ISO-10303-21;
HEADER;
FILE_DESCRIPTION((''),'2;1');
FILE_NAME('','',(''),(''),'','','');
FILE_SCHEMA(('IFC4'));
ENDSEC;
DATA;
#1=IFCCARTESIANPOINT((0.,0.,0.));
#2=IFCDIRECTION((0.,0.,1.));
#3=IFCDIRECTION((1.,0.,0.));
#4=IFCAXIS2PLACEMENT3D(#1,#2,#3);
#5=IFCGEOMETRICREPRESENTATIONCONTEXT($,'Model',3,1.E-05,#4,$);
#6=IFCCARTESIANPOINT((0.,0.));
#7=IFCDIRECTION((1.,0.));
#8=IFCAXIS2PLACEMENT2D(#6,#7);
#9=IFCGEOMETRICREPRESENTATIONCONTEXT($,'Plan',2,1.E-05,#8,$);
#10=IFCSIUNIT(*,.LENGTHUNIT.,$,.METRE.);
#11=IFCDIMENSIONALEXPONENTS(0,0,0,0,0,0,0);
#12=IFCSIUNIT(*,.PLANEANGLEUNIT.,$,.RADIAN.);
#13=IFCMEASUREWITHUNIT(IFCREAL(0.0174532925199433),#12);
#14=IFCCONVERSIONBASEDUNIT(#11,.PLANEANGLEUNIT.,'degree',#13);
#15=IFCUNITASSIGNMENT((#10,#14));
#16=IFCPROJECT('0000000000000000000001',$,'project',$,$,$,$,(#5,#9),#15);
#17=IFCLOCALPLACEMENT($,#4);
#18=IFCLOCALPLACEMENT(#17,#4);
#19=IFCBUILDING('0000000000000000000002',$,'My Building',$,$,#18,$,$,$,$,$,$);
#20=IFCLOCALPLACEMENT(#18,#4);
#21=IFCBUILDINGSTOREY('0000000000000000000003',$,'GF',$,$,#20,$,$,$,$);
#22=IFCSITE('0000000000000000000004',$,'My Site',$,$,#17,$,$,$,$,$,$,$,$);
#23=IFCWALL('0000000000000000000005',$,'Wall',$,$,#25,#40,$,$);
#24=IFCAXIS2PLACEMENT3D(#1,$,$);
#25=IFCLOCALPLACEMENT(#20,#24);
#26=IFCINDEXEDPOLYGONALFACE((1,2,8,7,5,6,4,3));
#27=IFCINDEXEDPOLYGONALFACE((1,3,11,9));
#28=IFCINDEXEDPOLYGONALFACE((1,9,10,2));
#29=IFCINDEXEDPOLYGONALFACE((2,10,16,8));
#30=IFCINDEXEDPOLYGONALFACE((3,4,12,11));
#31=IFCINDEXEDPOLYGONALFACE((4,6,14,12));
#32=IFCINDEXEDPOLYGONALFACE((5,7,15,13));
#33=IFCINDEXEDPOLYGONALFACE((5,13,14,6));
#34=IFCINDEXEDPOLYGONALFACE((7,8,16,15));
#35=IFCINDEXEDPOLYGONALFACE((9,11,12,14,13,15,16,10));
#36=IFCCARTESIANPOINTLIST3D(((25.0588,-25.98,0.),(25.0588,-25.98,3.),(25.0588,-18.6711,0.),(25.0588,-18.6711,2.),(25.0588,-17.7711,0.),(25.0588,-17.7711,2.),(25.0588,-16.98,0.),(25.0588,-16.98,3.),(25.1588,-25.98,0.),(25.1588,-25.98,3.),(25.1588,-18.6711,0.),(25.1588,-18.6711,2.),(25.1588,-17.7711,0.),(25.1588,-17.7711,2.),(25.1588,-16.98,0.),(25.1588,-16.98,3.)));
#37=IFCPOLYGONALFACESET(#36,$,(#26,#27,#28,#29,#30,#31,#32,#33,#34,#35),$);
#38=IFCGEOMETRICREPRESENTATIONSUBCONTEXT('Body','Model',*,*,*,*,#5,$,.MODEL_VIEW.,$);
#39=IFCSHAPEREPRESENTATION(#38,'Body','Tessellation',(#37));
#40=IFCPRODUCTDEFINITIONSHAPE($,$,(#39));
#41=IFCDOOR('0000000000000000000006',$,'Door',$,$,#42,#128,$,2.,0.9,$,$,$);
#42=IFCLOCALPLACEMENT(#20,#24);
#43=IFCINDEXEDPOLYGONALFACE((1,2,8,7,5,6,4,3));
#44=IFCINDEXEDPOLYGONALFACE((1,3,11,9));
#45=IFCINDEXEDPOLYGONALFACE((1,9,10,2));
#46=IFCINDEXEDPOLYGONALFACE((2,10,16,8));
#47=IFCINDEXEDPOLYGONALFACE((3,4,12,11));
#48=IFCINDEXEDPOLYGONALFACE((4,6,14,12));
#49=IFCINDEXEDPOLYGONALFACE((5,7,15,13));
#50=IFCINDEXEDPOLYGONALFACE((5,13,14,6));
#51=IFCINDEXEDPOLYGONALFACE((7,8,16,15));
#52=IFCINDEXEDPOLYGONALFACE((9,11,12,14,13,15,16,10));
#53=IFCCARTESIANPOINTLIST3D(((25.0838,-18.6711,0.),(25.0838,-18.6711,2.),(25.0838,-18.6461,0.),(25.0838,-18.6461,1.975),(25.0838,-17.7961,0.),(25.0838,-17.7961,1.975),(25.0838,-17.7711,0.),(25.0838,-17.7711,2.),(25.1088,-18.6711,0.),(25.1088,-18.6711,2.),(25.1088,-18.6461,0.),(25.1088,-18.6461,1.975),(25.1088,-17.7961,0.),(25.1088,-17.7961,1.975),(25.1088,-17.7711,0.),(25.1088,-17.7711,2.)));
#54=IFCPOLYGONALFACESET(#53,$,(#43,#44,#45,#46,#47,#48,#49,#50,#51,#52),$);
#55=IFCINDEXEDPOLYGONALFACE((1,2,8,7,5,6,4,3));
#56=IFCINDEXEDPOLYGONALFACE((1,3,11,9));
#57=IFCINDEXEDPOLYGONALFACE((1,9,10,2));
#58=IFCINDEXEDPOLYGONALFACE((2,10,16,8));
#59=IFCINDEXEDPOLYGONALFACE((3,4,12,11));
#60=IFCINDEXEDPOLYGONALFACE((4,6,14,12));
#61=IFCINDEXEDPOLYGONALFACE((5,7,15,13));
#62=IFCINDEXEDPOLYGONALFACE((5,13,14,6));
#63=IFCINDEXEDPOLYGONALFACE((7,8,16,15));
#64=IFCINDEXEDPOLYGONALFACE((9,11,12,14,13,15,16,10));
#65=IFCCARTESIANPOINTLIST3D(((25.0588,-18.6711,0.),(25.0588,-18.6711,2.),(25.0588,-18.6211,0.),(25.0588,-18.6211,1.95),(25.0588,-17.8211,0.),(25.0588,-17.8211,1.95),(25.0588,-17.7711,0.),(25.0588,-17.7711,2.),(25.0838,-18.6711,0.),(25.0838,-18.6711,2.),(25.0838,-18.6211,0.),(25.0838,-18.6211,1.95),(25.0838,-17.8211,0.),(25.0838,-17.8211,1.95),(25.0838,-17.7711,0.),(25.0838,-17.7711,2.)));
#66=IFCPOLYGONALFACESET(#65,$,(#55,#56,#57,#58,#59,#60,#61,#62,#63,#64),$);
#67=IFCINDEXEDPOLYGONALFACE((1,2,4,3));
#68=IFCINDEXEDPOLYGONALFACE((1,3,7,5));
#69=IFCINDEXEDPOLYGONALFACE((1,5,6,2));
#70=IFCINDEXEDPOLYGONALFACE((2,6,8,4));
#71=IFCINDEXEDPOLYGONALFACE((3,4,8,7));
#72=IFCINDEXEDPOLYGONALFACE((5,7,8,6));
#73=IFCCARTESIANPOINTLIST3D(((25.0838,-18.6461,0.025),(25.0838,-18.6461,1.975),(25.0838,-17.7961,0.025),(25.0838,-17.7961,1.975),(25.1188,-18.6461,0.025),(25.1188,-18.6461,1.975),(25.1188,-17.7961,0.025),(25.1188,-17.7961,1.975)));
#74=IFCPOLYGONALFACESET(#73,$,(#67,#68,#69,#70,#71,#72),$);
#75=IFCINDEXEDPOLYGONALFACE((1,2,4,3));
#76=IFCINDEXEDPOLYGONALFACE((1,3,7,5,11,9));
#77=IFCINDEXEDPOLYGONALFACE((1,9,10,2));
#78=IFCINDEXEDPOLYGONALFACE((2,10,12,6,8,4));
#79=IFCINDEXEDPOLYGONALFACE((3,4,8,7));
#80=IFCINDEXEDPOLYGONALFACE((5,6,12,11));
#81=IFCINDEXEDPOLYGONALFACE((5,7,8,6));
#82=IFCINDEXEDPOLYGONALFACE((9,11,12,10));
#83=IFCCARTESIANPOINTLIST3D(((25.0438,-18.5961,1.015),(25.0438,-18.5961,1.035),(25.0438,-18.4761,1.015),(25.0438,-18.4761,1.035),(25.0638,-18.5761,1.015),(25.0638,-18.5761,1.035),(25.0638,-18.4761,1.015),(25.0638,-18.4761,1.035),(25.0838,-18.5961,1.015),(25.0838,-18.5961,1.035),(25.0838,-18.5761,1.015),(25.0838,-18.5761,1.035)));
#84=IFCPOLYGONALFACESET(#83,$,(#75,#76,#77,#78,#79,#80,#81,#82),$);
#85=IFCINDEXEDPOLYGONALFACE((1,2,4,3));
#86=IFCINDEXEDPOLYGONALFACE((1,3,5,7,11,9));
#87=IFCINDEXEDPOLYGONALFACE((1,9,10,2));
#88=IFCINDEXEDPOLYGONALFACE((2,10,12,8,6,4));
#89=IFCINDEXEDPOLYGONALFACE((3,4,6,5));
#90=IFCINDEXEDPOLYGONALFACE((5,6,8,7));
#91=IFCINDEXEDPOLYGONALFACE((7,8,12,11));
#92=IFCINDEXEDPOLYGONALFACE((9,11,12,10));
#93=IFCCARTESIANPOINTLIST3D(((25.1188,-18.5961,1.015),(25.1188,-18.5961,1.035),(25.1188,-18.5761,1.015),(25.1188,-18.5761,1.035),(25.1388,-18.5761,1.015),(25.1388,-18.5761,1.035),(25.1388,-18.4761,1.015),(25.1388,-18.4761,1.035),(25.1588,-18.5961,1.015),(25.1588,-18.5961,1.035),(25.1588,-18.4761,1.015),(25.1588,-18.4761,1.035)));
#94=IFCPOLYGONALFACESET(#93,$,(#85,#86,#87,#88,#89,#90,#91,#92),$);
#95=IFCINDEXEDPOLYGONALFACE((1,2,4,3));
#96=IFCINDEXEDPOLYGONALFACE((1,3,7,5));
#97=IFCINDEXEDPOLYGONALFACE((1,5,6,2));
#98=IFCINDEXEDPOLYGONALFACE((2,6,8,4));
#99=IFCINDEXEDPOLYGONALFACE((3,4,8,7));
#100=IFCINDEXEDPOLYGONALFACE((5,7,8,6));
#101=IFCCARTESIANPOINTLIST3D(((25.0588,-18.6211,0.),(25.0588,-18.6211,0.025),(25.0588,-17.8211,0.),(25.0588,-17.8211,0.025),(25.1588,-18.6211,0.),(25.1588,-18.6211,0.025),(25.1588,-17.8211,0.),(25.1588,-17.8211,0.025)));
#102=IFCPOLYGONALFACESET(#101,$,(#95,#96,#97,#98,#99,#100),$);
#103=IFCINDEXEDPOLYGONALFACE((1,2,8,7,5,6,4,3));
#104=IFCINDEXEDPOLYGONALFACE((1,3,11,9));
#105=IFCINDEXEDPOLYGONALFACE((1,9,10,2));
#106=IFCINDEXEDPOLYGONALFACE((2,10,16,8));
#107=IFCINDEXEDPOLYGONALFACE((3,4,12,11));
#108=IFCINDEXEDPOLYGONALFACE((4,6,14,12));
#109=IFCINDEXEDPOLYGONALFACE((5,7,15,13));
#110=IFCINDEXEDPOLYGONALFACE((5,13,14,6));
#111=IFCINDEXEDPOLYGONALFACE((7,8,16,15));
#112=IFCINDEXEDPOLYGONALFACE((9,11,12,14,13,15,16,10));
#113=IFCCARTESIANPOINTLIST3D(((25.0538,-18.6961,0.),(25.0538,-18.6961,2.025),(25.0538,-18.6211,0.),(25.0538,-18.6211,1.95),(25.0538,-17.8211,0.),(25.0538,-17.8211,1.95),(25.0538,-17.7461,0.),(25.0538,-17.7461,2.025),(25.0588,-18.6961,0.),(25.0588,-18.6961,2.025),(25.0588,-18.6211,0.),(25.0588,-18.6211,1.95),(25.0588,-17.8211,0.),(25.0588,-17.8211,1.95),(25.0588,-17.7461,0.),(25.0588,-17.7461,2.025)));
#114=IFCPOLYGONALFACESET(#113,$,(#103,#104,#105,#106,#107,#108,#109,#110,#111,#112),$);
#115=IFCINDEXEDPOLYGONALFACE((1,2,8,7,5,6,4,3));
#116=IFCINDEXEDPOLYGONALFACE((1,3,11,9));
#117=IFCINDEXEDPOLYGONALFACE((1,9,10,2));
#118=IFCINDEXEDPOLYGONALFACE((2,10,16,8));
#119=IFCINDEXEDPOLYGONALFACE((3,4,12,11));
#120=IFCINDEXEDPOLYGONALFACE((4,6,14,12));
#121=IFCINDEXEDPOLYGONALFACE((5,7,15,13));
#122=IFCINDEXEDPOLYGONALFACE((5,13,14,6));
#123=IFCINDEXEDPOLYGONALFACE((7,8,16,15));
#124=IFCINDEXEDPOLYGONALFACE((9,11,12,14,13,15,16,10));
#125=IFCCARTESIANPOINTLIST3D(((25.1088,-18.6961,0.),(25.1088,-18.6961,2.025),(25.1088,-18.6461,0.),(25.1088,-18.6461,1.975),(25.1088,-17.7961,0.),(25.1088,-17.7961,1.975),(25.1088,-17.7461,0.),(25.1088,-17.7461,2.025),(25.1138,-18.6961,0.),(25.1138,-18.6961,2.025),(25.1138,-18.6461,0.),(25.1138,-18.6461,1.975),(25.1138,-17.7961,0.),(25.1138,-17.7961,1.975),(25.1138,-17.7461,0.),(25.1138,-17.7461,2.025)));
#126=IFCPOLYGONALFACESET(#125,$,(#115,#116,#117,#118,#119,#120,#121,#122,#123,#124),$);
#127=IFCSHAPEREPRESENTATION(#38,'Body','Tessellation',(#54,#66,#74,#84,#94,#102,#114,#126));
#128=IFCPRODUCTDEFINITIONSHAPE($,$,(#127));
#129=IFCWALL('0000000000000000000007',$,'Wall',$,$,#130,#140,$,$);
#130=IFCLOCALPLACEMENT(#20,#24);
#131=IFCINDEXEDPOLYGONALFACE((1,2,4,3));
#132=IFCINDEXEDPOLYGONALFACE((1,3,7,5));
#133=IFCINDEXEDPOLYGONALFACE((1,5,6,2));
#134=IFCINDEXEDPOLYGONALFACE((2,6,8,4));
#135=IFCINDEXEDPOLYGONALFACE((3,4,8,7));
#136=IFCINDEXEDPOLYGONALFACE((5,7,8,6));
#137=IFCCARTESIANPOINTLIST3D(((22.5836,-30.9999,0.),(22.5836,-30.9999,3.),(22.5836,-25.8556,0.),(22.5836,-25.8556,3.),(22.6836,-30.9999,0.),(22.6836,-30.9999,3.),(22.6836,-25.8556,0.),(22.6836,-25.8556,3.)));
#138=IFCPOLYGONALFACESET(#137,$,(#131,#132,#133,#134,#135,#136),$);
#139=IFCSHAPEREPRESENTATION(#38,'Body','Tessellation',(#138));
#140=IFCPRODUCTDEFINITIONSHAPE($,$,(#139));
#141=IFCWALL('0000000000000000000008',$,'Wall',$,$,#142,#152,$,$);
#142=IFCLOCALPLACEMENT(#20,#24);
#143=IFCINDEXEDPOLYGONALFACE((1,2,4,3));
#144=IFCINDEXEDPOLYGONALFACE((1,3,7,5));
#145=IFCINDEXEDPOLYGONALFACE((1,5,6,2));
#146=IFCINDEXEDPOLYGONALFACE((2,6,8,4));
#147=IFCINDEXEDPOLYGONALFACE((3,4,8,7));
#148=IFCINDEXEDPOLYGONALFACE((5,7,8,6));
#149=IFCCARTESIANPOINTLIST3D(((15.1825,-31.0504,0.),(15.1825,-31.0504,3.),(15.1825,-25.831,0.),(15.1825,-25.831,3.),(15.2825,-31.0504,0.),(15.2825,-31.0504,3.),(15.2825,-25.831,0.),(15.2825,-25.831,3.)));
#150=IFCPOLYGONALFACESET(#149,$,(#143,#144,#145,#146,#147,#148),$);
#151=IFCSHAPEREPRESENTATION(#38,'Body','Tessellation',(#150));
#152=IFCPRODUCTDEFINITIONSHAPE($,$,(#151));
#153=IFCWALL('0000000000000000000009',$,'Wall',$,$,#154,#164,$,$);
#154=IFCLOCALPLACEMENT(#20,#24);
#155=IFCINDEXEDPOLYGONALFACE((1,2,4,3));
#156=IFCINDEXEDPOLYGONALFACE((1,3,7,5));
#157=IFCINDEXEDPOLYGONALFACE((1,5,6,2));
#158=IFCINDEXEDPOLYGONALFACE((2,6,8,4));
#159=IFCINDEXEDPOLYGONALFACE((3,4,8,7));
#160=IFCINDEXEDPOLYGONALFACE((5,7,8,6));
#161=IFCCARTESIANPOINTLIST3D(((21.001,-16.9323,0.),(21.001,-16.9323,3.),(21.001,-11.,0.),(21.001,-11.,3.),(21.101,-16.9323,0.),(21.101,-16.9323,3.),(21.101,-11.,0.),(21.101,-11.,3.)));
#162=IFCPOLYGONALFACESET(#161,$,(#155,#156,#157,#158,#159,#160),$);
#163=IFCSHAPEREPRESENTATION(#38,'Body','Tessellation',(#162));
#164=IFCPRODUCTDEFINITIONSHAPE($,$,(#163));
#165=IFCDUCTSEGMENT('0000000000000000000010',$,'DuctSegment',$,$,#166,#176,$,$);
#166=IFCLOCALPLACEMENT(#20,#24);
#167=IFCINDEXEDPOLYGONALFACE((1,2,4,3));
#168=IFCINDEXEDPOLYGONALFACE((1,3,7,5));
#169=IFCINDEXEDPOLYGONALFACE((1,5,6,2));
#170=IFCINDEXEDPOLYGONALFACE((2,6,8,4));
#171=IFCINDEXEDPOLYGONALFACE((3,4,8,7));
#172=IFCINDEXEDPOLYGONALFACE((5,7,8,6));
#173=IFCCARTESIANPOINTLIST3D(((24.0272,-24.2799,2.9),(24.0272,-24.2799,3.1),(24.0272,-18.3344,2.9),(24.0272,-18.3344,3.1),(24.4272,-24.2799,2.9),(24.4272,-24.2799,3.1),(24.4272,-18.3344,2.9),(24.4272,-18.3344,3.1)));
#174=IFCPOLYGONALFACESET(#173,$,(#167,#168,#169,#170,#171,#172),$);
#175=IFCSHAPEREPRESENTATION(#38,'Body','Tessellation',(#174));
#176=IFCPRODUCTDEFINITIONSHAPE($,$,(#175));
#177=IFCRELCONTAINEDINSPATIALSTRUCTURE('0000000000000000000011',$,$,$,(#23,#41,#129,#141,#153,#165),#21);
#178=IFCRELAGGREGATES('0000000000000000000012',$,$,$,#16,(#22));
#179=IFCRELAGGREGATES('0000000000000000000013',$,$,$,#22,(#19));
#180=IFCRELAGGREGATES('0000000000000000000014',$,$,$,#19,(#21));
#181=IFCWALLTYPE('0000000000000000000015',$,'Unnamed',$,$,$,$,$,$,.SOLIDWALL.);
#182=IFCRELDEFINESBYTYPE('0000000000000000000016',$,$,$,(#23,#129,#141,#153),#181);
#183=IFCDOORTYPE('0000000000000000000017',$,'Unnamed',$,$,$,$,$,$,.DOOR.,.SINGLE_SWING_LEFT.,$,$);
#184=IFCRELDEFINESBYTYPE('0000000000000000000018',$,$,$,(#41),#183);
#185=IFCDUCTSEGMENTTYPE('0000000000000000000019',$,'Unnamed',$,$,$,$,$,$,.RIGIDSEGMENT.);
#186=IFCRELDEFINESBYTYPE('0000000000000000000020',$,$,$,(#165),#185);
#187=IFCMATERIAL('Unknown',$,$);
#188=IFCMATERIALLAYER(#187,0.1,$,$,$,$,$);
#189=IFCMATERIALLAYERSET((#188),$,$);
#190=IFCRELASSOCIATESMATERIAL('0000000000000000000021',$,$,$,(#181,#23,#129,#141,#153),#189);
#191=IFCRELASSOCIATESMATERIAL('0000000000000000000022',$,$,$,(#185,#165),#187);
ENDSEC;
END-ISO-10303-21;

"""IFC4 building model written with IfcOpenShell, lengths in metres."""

from ifc_helpers import new_model, entity, si_unit, converted_unit, frame, origin_with_axes, origin_2d_with_axis, place, context, subcontext, project, spatial, line, indexed_curve, rectangle, outline, extrude, shape, source, transform, mapped, material, layer, layer_set, layer_usage, material_profile, profile_set, profile_usage, type_object, type_shapes, element, fill, save


model = new_model("IFC4")

# Units and contexts
model_context = context("Model", 3, precision=1e-05, world=origin_with_axes())
plan_context = context("Plan", 2, precision=1e-05, world=origin_2d_with_axis())
body_context_1 = subcontext(model_context, "Body", "Model", "MODEL_VIEW")
body_context_2 = subcontext(plan_context, "Body", "Plan", "PLAN_VIEW")
ifc_project = project(units=[si_unit("LENGTHUNIT", "METRE"), converted_unit("PLANEANGLEUNIT", "degree", entity("IfcReal", 0.0174532925199433), si_unit("PLANEANGLEUNIT", "RADIAN"), dimensions=[0, 0, 0, 0, 0, 0, 0])], contexts=[model_context, plan_context])

# Site, building, storey
site_placement = place(None, origin_with_axes())
site = spatial("IfcSite", under=ifc_project, at=site_placement, Name="My Site")
building_placement = place(site_placement, origin_with_axes())
building = spatial("IfcBuilding", under=site, at=building_placement, Name="My Building")
storey_placement = place(building_placement, origin_with_axes())
storey = spatial("IfcBuildingStorey", under=building, at=storey_placement, Name="GF")

# Shared definitions
ifc_material = material(Name="Unknown")
ifc_layer = layer(ifc_material, 0.1)
ifc_layer_set = layer_set([ifc_layer])
wall_type = type_object("IfcWallType", Name="Unnamed", PredefinedType="SOLIDWALL", material=ifc_layer_set)

# Shared definitions
shared_shape_1 = source(origin_with_axes(), body_context_1, "Body", "SweptSolid", [
    extrude(outline(indexed_curve([(0.0, 0.0), (0.9, 0.0), (0.9, 2.0), (0.0, 2.0)], segments=[line(1, 2, 3, 4, 1)])), frame((0.0, -0.6, 0.0), z_axis=(0.0, -1.0, 0.0), x_axis=(1.0, 0.0, 0.0)), (0.0, 0.0, -1.0), 1.2),
])
door_type = type_object("IfcDoorType", Name="Unnamed", OperationType="SINGLE_SWING_LEFT", PredefinedType="DOOR")
shared_shape_2 = source(origin_with_axes(), body_context_1, "Body", "SweptSolid", [
    extrude(outline(indexed_curve([(0.0, 0.0), (0.0, 2.0), (0.9, 2.0), (0.9, 0.0), (0.875, 0.0), (0.875, 1.975), (0.025, 1.975), (0.025, 0.0)], segments=[line(1, 2, 3, 4, 5, 6, 7, 8, 1)])), frame((0.0, 0.025, 0.0), z_axis=(0.0, -1.0, 0.0), x_axis=(1.0, 0.0, 0.0)), (0.0, 0.0, -1.0), 0.025),
    extrude(outline(indexed_curve([(0.0, 0.0), (0.0, 2.0), (0.9, 2.0), (0.9, 0.0), (0.85, 0.0), (0.85, 1.95), (0.05, 1.95), (0.05, 0.0)], segments=[line(1, 2, 3, 4, 5, 6, 7, 8, 1)])), frame((0.0, 0.0, 0.0), z_axis=(0.0, -1.0, 0.0), x_axis=(1.0, 0.0, 0.0)), (0.0, 0.0, -1.0), 0.025),
    extrude(outline(indexed_curve([(0.0, 0.0), (0.85, 0.0), (0.85, 0.035), (0.0, 0.035)], segments=[line(1, 2, 3, 4, 1)])), frame((0.025, 0.025, 0.025), z_axis=(0.0, 0.0, 1.0), x_axis=(1.0, 0.0, 0.0)), (0.0, 0.0, 1.0), 1.95),
    extrude(outline(indexed_curve([(0.0, 0.0), (0.0, -0.04), (-0.12, -0.04), (-0.12, -0.02), (-0.02, -0.02), (-0.02, 0.0)], segments=[line(1, 2, 3, 4, 5, 6, 1)])), frame((0.825, 0.025, 1.015), z_axis=(0.0, 0.0, 1.0), x_axis=(1.0, 0.0, 0.0)), (0.0, 0.0, 1.0), 0.02),
    extrude(outline(indexed_curve([(0.0, 0.0), (0.0, 0.04), (-0.12, 0.04), (-0.12, 0.02), (-0.02, 0.02), (-0.02, 0.0)], segments=[line(1, 2, 3, 4, 5, 6, 1)])), frame((0.825, 0.06, 1.015), z_axis=(0.0, 0.0, 1.0), x_axis=(1.0, 0.0, 0.0)), (0.0, 0.0, 1.0), 0.02),
    extrude(outline(indexed_curve([(0.0, 0.0), (0.8, 0.0), (0.8, 0.1), (0.0, 0.1)], segments=[line(1, 2, 3, 4, 1)])), frame((0.05, 0.0, 0.0), z_axis=(0.0, 0.0, 1.0), x_axis=(1.0, 0.0, 0.0)), (0.0, 0.0, 1.0), 0.025),
    extrude(outline(indexed_curve([(0.0, 0.0), (0.0, 2.025), (0.95, 2.025), (0.95, 0.0), (0.875, 0.0), (0.875, 1.95), (0.075, 1.95), (0.075, 0.0)], segments=[line(1, 2, 3, 4, 5, 6, 7, 8, 1)])), frame((-0.025, -0.005, 0.0), z_axis=(0.0, -1.0, 0.0), x_axis=(1.0, 0.0, 0.0)), (0.0, 0.0, -1.0), 0.005),
    extrude(outline(indexed_curve([(0.0, 0.0), (0.0, 2.025), (0.95, 2.025), (0.95, 0.0), (0.9, 0.0), (0.9, 1.975), (0.05, 1.975), (0.05, 0.0)], segments=[line(1, 2, 3, 4, 5, 6, 7, 8, 1)])), frame((-0.025, 0.05, 0.0), z_axis=(0.0, -1.0, 0.0), x_axis=(1.0, 0.0, 0.0)), (0.0, 0.0, -1.0), 0.005),
])
shared_shape_3 = source(origin_with_axes(), body_context_2, "Body", "Curve2D", [
    entity("IfcIndexedPolyCurve", entity("IfcCartesianPointList2D", [[0.0, 0.0], [0.0, 0.05], [0.025, 0.05], [0.025, 0.025], [0.05, 0.025], [0.05, 0.0]]), [entity("IfcLineIndex", [1, 2, 3, 4, 5, 6, 1])]),
    entity("IfcIndexedPolyCurve", entity("IfcCartesianPointList2D", [[0.9, 0.0], [0.9, 0.05], [0.875, 0.05], [0.875, 0.025], [0.85, 0.025], [0.85, 0.0]]), [entity("IfcLineIndex", [1, 2, 3, 4, 5, 6, 1])]),
    entity("IfcTrimmedCurve", entity("IfcEllipse", entity("IfcAxis2Placement2D", entity("IfcCartesianPoint", [0.06, 0.05]), entity("IfcDirection", [1.0, 0.0])), 0.815, 0.85), [entity("IfcCartesianPoint", [0.875, 0.05])], [entity("IfcCartesianPoint", [0.06, 0.9])], True, "CARTESIAN"),
    entity("IfcIndexedPolyCurve", entity("IfcCartesianPointList2D", [[0.025, 0.05], [0.06, 0.05], [0.06, 0.9], [0.025, 0.9]]), [entity("IfcLineIndex", [1, 2, 3, 4, 1])]),
])
type_shapes(door_type, [shared_shape_2, shared_shape_3])

# Wall, opening, door
ifc_layer_usage_1 = layer_usage(ifc_layer_set, "AXIS2", "POSITIVE", 0.0)
wall_1_placement = place(storey_placement, frame((25.0588, -16.98, 0.0), z_axis=(0.0, 0.0, 1.0), x_axis=(0.0, -1.0, 0.0)))
wall_1 = element("IfcWall", 1, at=wall_1_placement, inside=storey, type_object=wall_type, material=ifc_layer_usage_1, Name="Wall", context=body_context_1, shape_type="SweptSolid", body=[
    extrude(outline(indexed_curve([(0.0, 0.0), (0.0, 0.1), (9.0, 0.1), (9.0, 0.0)], segments=[line(1, 2, 3, 4, 1)])), origin_with_axes(), (0.0, 0.0, 1.0), 3.0),
])
opening_1_placement = place(wall_1_placement, frame((0.7911, 0.0, 0.0), z_axis=(0.0, 0.0, 1.0), x_axis=(1.0, 0.0, 0.0)))
opening_1 = element("IfcOpeningElement", 2, at=opening_1_placement, cuts=wall_1, PredefinedType="OPENING", context=body_context_1, shape_type="MappedRepresentation", body=[
    mapped(shared_shape_1, transform((0.0, 0.0, 0.0), x_axis=(1.0, 0.0, 0.0), y_axis=(0.0, 1.0, 0.0), z_axis=(0.0, 0.0, 1.0), scale=1.0)),
])
door_1_placement = place(opening_1_placement, frame((0.0, 0.0, 0.0), z_axis=(0.0, 0.0, 1.0), x_axis=(1.0, 0.0, 0.0)))
door_1 = element("IfcDoor", 3, at=door_1_placement, inside=storey, type_object=door_type, Name="Door", OverallHeight=2.0, OverallWidth=0.9, shapes=[
    shape(body_context_1, "Body", "MappedRepresentation", [mapped(shared_shape_2, transform((0.0, 0.0, 0.0), x_axis=(1.0, 0.0, 0.0), y_axis=(0.0, 1.0, 0.0), z_axis=(0.0, 0.0, 1.0), scale=1.0))]),
    shape(body_context_2, "Body", "MappedRepresentation", [mapped(shared_shape_3, transform((0.0, 0.0, 0.0), x_axis=(1.0, 0.0, 0.0), y_axis=(0.0, 1.0, 0.0), z_axis=(0.0, 0.0, 1.0), scale=1.0))]),
])
fill(opening_1, door_1)

# Walls
ifc_layer_usage_2 = layer_usage(ifc_layer_set, "AXIS2", "POSITIVE", 0.0)
wall_2_placement = place(storey_placement, frame((22.5836, -25.8556, 0.0), z_axis=(0.0, 0.0, 1.0), x_axis=(0.0, -1.0, 0.0)))
element("IfcWall", 4, at=wall_2_placement, inside=storey, type_object=wall_type, material=ifc_layer_usage_2, Name="Wall", context=body_context_1, shape_type="SweptSolid", body=[
    extrude(outline(indexed_curve([(0.0, 0.0), (0.0, 0.1), (5.1443, 0.1), (5.1443, 0.0)], segments=[line(1, 2, 3, 4, 1)])), origin_with_axes(), (0.0, 0.0, 1.0), 3.0),
])
ifc_layer_usage_3 = layer_usage(ifc_layer_set, "AXIS2", "POSITIVE", 0.0)
wall_3_placement = place(storey_placement, frame((15.1825, -25.831, 0.0), z_axis=(0.0, 0.0, 1.0), x_axis=(0.0, -1.0, 0.0)))
element("IfcWall", 5, at=wall_3_placement, inside=storey, type_object=wall_type, material=ifc_layer_usage_3, Name="Wall", context=body_context_1, shape_type="SweptSolid", body=[
    extrude(outline(indexed_curve([(0.0, 0.0), (0.0, 0.1), (5.2194, 0.1), (5.2194, 0.0)], segments=[line(1, 2, 3, 4, 1)])), origin_with_axes(), (0.0, 0.0, 1.0), 3.0),
])
ifc_layer_usage_4 = layer_usage(ifc_layer_set, "AXIS2", "POSITIVE", 0.0)
wall_4_placement = place(storey_placement, frame((21.101, -16.9323, 0.0), z_axis=(0.0, 0.0, 1.0), x_axis=(0.0, 1.0, 0.0)))
element("IfcWall", 6, at=wall_4_placement, inside=storey, type_object=wall_type, material=ifc_layer_usage_4, Name="Wall", context=body_context_1, shape_type="SweptSolid", body=[
    extrude(outline(indexed_curve([(0.0, 0.0), (0.0, 0.1), (5.9323, 0.1), (5.9323, 0.0)], segments=[line(1, 2, 3, 4, 1)])), origin_with_axes(), (0.0, 0.0, 1.0), 3.0),
])

# Duct segment
ifc_material_profile_1 = material_profile(ifc_material, rectangle(XDim=0.4, YDim=0.2))
ifc_profile_set_1 = profile_set([ifc_material_profile_1])
ifc_profile_usage_1 = profile_usage(ifc_profile_set_1, cardinal=5)
duct_segment_type = type_object("IfcDuctSegmentType", Name="Unnamed", PredefinedType="RIGIDSEGMENT", material=ifc_profile_set_1)
duct_segment_1_placement = place(storey_placement, frame((24.2272, -24.2799, 3.0), z_axis=(0.0, 1.0, 0.0), x_axis=(-1.0, 0.0, 0.0)))
element("IfcDuctSegment", 7, at=duct_segment_1_placement, inside=storey, type_object=duct_segment_type, material=ifc_profile_usage_1, Name="DuctSegment", context=body_context_1, shape_type="SweptSolid", body=[
    extrude(rectangle(XDim=0.4, YDim=0.2), origin_with_axes(), (0.0, 0.0, 1.0), 5.9455),
])

save(model, "model.ifc")
